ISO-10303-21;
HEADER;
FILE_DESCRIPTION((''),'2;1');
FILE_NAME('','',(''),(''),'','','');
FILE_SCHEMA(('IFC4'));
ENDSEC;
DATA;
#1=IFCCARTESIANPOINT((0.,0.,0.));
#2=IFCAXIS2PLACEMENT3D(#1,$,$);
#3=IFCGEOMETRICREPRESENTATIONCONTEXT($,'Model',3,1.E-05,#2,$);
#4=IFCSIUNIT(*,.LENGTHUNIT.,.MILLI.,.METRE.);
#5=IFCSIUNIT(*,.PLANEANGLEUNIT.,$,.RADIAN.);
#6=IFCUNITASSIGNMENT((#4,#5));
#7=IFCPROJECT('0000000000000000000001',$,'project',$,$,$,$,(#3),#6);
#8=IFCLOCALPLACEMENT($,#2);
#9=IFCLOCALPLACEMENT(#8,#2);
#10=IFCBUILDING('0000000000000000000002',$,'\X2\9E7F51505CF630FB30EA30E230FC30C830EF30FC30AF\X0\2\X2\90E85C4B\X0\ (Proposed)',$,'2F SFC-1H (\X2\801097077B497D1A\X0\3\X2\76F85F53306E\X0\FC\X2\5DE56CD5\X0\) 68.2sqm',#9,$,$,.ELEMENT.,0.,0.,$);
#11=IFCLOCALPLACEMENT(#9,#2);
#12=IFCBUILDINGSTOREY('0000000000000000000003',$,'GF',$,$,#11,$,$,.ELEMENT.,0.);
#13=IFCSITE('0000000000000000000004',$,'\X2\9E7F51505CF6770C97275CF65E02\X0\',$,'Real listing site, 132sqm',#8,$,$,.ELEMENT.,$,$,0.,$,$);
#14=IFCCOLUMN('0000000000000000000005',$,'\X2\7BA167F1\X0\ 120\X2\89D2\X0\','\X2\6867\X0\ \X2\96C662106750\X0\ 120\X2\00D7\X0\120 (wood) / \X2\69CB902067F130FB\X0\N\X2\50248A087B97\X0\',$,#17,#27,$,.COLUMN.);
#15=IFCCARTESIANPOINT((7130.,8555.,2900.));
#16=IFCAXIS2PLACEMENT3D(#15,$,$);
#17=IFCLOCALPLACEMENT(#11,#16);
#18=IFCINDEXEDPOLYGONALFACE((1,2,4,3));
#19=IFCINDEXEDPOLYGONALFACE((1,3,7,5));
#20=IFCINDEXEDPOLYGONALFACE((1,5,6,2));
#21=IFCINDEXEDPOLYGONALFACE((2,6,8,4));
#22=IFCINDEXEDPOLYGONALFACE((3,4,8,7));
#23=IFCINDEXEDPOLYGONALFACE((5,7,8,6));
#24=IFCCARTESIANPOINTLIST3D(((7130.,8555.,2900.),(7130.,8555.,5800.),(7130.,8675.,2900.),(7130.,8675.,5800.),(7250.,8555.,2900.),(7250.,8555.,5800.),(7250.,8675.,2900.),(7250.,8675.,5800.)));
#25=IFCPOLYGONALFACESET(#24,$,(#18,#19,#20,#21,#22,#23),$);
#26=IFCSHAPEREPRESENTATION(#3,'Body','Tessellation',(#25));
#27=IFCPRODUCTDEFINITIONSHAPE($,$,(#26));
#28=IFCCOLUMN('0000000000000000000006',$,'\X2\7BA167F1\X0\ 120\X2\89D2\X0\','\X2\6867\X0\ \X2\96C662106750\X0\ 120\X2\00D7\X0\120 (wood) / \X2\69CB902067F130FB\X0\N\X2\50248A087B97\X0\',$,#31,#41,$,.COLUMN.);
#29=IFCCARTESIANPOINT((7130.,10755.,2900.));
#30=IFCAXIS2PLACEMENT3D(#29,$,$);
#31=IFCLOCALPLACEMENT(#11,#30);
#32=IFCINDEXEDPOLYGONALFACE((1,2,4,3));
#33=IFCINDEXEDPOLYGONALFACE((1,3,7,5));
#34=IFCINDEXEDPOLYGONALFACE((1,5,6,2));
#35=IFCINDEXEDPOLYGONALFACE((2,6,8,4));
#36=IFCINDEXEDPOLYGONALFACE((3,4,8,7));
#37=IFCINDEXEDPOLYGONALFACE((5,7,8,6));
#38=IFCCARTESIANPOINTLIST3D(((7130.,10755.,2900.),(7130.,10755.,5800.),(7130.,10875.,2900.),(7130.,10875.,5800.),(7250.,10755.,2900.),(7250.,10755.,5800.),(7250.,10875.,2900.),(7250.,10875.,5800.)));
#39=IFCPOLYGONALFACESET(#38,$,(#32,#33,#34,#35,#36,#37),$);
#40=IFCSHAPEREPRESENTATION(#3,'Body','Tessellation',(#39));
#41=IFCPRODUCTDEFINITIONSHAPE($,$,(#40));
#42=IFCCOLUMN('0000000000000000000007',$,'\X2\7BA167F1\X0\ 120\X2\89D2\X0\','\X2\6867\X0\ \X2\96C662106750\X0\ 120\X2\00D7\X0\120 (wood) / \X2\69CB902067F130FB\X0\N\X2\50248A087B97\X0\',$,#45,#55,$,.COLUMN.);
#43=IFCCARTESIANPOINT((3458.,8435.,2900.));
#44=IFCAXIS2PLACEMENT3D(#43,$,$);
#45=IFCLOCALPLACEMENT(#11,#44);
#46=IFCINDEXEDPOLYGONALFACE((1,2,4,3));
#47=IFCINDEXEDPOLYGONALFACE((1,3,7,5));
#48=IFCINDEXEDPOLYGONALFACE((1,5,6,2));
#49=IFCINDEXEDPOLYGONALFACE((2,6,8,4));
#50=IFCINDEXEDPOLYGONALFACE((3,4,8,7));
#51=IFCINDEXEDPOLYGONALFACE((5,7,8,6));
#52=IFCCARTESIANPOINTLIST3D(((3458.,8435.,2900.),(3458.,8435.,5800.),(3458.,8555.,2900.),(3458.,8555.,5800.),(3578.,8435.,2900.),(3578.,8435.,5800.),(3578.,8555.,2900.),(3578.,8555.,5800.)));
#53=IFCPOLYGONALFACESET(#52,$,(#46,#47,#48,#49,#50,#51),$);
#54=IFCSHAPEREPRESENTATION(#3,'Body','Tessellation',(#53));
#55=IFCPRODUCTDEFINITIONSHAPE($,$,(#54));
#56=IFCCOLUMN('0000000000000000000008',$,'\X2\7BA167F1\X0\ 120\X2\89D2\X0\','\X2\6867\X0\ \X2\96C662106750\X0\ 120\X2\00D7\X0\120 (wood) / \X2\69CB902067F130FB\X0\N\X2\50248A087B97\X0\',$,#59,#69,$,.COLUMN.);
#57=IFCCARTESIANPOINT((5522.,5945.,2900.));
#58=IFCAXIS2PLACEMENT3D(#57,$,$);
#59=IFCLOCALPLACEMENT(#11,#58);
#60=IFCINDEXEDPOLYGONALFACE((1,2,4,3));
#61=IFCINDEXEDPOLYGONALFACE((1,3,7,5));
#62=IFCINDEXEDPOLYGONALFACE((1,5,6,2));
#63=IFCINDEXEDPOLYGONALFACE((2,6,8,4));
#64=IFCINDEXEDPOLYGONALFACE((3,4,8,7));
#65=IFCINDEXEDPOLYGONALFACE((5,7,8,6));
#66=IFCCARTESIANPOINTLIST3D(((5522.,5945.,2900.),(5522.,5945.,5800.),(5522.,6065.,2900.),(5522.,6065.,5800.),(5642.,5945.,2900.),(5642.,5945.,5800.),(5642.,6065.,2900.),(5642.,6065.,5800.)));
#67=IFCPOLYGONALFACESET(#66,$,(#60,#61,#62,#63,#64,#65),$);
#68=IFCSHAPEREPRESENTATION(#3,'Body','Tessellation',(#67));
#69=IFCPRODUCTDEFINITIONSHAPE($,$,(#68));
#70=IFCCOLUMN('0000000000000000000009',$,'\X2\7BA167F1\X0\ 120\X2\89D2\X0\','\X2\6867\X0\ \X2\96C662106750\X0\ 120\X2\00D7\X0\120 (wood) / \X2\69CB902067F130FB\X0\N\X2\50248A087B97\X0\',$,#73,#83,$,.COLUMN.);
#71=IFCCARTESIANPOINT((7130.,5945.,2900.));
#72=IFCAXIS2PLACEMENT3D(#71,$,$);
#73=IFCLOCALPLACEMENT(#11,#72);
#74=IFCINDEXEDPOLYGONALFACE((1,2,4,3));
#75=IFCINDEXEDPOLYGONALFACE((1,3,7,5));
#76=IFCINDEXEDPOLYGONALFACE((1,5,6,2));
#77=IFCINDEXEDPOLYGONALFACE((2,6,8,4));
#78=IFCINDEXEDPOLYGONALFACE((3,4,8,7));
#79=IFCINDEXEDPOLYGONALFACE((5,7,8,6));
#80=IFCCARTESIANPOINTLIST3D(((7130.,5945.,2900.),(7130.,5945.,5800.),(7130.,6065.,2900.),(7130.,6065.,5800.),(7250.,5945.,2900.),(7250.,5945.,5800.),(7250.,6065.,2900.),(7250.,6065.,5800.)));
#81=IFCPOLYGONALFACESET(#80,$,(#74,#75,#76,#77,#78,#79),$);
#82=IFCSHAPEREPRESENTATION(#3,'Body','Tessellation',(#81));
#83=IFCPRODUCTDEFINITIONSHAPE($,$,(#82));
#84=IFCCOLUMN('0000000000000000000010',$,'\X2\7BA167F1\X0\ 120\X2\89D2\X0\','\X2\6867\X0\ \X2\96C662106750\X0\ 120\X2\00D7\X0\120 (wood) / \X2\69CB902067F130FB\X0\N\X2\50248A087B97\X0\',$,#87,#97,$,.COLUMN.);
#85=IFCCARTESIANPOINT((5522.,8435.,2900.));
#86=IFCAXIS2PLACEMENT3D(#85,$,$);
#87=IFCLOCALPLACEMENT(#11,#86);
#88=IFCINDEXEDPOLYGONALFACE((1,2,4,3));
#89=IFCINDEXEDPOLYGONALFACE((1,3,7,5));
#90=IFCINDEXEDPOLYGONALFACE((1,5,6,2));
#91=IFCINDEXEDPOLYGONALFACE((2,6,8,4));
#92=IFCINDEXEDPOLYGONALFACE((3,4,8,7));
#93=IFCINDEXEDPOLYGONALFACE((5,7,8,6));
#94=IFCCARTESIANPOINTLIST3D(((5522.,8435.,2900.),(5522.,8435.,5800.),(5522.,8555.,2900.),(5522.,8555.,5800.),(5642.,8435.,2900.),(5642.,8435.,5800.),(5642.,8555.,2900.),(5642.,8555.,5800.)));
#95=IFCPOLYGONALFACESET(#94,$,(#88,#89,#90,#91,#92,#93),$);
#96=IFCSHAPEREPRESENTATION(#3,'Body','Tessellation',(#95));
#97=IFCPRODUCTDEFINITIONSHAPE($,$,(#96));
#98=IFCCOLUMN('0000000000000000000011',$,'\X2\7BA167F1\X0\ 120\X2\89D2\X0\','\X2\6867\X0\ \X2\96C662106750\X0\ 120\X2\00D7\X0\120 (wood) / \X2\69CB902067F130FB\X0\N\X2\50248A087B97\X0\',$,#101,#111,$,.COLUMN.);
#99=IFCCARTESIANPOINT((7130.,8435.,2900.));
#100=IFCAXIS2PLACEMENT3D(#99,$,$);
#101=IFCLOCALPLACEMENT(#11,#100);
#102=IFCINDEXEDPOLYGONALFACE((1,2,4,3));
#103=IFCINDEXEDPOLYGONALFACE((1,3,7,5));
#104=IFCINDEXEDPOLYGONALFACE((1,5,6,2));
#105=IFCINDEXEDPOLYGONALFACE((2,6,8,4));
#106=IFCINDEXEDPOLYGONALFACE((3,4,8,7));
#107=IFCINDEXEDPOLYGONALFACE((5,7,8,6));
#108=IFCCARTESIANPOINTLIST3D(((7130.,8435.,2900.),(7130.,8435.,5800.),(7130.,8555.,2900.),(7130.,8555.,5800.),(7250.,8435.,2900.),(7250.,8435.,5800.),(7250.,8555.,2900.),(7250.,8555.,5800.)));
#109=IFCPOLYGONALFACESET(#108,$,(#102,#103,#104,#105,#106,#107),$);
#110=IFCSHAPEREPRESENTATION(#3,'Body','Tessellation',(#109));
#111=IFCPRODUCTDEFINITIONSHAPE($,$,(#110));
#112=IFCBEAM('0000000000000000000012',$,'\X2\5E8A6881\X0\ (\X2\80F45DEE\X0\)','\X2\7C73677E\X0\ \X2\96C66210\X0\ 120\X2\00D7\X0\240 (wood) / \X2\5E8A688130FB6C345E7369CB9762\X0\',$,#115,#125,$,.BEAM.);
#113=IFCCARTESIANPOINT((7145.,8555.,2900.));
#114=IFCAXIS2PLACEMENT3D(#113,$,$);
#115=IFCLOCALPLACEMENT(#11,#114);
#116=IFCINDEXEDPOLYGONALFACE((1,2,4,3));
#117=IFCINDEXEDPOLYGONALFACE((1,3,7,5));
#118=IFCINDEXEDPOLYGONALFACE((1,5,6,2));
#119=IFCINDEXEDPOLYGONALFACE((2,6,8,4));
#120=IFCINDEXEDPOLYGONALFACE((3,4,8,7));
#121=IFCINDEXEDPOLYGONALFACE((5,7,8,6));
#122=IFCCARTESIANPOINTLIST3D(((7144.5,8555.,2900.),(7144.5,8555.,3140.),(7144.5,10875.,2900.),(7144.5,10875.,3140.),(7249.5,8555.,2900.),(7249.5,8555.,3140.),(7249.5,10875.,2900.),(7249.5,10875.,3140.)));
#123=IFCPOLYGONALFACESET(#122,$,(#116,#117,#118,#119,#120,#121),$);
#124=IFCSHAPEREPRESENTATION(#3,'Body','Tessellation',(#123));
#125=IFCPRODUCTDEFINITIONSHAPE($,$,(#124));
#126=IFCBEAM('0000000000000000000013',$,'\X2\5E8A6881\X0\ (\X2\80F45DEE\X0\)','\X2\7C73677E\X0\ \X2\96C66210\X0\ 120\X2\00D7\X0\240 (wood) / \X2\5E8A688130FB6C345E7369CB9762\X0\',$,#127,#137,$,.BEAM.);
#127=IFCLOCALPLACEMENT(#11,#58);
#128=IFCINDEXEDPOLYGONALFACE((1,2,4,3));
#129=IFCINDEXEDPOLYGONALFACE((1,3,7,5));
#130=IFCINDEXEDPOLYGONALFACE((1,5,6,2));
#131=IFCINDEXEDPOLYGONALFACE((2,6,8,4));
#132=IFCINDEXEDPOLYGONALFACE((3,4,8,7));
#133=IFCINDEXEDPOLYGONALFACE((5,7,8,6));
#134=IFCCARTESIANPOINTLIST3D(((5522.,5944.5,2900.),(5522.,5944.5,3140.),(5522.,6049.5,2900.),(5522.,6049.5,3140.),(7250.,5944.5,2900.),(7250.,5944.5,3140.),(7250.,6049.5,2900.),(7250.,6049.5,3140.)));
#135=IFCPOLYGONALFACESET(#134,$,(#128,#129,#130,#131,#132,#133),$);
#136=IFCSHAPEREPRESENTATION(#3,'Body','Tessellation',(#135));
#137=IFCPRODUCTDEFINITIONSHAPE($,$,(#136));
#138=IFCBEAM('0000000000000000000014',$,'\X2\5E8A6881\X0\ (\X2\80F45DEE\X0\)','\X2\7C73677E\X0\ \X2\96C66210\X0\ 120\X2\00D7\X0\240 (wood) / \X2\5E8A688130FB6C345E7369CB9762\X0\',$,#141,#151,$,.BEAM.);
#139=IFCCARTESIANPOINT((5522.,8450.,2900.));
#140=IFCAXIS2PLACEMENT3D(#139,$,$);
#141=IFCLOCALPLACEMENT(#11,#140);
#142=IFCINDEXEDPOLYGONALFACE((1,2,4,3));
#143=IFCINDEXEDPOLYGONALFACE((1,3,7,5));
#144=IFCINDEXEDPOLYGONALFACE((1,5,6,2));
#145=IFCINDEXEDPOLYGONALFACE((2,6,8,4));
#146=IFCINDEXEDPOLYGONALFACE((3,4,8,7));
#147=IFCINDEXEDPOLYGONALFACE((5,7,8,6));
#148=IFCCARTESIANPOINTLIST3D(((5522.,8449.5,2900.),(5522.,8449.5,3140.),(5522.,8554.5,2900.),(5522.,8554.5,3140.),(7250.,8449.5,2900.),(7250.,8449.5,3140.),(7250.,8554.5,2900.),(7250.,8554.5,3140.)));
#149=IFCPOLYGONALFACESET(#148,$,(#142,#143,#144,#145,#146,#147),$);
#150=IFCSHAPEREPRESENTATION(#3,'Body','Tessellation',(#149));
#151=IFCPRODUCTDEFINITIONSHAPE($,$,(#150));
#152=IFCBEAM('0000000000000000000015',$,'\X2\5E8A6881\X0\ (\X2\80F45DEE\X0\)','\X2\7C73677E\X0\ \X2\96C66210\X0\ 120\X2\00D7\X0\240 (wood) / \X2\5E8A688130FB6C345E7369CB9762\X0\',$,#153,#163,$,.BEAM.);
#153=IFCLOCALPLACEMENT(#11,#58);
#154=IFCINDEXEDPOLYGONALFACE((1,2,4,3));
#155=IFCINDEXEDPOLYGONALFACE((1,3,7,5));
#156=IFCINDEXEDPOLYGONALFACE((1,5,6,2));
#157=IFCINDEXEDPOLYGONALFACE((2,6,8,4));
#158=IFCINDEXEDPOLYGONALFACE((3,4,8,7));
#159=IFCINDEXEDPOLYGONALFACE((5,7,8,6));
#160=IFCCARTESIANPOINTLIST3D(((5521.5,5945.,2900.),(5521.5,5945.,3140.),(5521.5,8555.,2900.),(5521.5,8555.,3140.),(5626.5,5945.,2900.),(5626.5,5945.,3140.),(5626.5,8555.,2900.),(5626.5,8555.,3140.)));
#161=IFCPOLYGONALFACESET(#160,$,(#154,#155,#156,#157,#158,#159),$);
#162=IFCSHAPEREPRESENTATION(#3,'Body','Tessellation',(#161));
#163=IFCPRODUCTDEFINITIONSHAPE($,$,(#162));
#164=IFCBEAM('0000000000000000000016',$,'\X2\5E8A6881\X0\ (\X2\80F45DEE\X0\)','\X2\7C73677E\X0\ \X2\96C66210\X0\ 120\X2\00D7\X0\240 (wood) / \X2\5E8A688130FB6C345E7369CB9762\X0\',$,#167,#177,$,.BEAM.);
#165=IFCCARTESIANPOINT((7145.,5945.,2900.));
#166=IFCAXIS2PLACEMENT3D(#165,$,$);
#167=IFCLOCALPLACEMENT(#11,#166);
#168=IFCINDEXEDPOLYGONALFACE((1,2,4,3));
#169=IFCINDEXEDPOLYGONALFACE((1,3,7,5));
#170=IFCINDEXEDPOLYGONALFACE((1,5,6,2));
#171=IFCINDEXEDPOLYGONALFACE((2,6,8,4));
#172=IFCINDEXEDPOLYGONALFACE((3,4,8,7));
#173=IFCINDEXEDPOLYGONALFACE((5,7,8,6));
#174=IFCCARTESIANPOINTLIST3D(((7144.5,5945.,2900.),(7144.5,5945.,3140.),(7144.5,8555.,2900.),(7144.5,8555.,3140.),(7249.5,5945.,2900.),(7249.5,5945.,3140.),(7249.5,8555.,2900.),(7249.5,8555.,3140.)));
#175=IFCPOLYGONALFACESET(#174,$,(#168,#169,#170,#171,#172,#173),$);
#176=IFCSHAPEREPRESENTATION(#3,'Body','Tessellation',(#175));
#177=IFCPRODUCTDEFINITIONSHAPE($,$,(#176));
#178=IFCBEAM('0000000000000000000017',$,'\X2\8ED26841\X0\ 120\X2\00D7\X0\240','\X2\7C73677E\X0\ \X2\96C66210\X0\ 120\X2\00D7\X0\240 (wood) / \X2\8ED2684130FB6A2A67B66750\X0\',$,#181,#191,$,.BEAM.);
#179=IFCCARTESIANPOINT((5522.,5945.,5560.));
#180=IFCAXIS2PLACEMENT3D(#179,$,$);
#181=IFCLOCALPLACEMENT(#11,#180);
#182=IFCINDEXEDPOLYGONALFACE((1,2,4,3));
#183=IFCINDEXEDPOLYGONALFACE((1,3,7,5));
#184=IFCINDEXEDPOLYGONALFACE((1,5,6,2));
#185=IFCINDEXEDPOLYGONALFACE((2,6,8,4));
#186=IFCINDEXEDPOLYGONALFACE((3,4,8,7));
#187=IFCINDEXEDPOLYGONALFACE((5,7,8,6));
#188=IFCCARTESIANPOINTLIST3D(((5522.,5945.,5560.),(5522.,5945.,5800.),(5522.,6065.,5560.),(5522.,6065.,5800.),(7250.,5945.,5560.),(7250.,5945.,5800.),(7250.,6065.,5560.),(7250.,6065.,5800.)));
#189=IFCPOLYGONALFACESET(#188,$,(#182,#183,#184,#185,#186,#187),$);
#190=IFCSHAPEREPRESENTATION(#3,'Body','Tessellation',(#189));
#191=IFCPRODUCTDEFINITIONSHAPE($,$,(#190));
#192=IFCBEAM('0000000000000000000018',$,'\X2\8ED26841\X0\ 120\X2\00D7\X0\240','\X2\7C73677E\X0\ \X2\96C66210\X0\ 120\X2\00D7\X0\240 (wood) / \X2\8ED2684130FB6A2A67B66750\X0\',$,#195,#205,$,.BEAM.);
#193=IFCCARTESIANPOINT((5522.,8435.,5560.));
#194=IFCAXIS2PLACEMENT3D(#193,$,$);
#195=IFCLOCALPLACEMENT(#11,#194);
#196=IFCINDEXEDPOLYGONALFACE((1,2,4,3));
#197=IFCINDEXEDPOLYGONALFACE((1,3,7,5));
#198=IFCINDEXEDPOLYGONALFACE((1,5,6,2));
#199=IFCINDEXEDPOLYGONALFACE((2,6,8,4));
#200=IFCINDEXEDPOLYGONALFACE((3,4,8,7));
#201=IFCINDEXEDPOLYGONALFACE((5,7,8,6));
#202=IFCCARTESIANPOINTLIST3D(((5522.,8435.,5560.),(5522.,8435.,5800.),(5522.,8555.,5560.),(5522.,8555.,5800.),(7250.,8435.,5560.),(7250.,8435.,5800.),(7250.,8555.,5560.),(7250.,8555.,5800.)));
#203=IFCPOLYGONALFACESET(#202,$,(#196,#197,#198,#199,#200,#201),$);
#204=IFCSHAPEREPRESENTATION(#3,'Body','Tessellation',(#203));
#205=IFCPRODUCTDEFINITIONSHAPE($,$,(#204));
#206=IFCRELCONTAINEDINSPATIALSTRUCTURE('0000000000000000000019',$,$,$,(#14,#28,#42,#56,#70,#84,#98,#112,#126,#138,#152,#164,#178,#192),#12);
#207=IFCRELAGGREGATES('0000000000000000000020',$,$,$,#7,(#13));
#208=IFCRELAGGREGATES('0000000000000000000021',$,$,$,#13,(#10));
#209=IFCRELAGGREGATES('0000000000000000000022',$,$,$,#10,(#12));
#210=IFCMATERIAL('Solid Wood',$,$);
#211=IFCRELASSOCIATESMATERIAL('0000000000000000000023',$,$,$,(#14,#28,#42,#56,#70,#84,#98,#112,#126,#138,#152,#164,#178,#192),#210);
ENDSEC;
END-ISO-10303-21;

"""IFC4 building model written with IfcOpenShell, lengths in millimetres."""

from ifc_helpers import new_model, si_unit, frame, frame_2d, origin, place, context, project, spatial, rectangle, extrude, material, element, save


model = new_model("IFC4")

# Units and contexts
model_context = context("Model", 3, precision=1e-05, world=origin())
ifc_project = project(units=[si_unit("LENGTHUNIT", "METRE", prefix="MILLI"), si_unit("PLANEANGLEUNIT", "RADIAN")], contexts=[model_context])

# Site, building, storey
site_placement = place(None, origin())
site = spatial("IfcSite", under=ifc_project, at=site_placement, Name="鹿児島県霧島市", ObjectType="Real listing site, 132sqm", CompositionType="ELEMENT", RefElevation=0.0)
building_placement = place(site_placement, origin())
building = spatial("IfcBuilding", under=site, at=building_placement, Name="鹿児島・リモートワーク2部屋 (Proposed)", ObjectType="2F SFC-1H (耐震等級3相当のFC工法) 68.2sqm", CompositionType="ELEMENT", ElevationOfRefHeight=0.0, ElevationOfTerrain=0.0)
storey_placement = place(building_placement, origin())
storey = spatial("IfcBuildingStorey", under=building, at=storey_placement, Name="GF", CompositionType="ELEMENT", Elevation=0.0)

# Columns
ifc_material_1 = material(Name="Solid Wood")
column_1_placement = place(storey_placement, frame((7130.0, 8555.0, 2900.0)))
element("IfcColumn", 1, at=column_1_placement, inside=storey, material=ifc_material_1, Name="管柱 120角", Description="桧 集成材 120×120 (wood) / 構造柱・N値計算", PredefinedType="COLUMN", context=model_context, shape_type="SweptSolid", body=[
    extrude(rectangle(XDim=120.0, YDim=120.0, at=frame_2d((60.0, 60.0))), frame((7130.0, 8555.0, 2900.0)), (0.0, 0.0, 1.0), 2900.0),
])
column_2_placement = place(storey_placement, frame((7130.0, 10755.0, 2900.0)))
element("IfcColumn", 2, at=column_2_placement, inside=storey, material=ifc_material_1, Name="管柱 120角", Description="桧 集成材 120×120 (wood) / 構造柱・N値計算", PredefinedType="COLUMN", context=model_context, shape_type="SweptSolid", body=[
    extrude(rectangle(XDim=120.0, YDim=120.0, at=frame_2d((60.0, 60.0))), frame((7130.0, 10755.0, 2900.0)), (0.0, 0.0, 1.0), 2900.0),
])
column_3_placement = place(storey_placement, frame((3458.0, 8435.0, 2900.0)))
element("IfcColumn", 3, at=column_3_placement, inside=storey, material=ifc_material_1, Name="管柱 120角", Description="桧 集成材 120×120 (wood) / 構造柱・N値計算", PredefinedType="COLUMN", context=model_context, shape_type="SweptSolid", body=[
    extrude(rectangle(XDim=120.0, YDim=120.0, at=frame_2d((60.0, 60.0))), frame((3458.0, 8435.0, 2900.0)), (0.0, 0.0, 1.0), 2900.0),
])
column_4_placement = place(storey_placement, frame((5522.0, 5945.0, 2900.0)))
element("IfcColumn", 4, at=column_4_placement, inside=storey, material=ifc_material_1, Name="管柱 120角", Description="桧 集成材 120×120 (wood) / 構造柱・N値計算", PredefinedType="COLUMN", context=model_context, shape_type="SweptSolid", body=[
    extrude(rectangle(XDim=120.0, YDim=120.0, at=frame_2d((60.0, 60.0))), frame((5522.0, 5945.0, 2900.0)), (0.0, 0.0, 1.0), 2900.0),
])
column_5_placement = place(storey_placement, frame((7130.0, 5945.0, 2900.0)))
element("IfcColumn", 5, at=column_5_placement, inside=storey, material=ifc_material_1, Name="管柱 120角", Description="桧 集成材 120×120 (wood) / 構造柱・N値計算", PredefinedType="COLUMN", context=model_context, shape_type="SweptSolid", body=[
    extrude(rectangle(XDim=120.0, YDim=120.0, at=frame_2d((60.0, 60.0))), frame((7130.0, 5945.0, 2900.0)), (0.0, 0.0, 1.0), 2900.0),
])
column_6_placement = place(storey_placement, frame((5522.0, 8435.0, 2900.0)))
element("IfcColumn", 6, at=column_6_placement, inside=storey, material=ifc_material_1, Name="管柱 120角", Description="桧 集成材 120×120 (wood) / 構造柱・N値計算", PredefinedType="COLUMN", context=model_context, shape_type="SweptSolid", body=[
    extrude(rectangle(XDim=120.0, YDim=120.0, at=frame_2d((60.0, 60.0))), frame((5522.0, 8435.0, 2900.0)), (0.0, 0.0, 1.0), 2900.0),
])
column_7_placement = place(storey_placement, frame((7130.0, 8435.0, 2900.0)))
element("IfcColumn", 7, at=column_7_placement, inside=storey, material=ifc_material_1, Name="管柱 120角", Description="桧 集成材 120×120 (wood) / 構造柱・N値計算", PredefinedType="COLUMN", context=model_context, shape_type="SweptSolid", body=[
    extrude(rectangle(XDim=120.0, YDim=120.0, at=frame_2d((60.0, 60.0))), frame((7130.0, 8435.0, 2900.0)), (0.0, 0.0, 1.0), 2900.0),
])

# Beams
beam_1_placement = place(storey_placement, frame((7145.0, 8555.0, 2900.0)))
element("IfcBeam", 8, at=beam_1_placement, inside=storey, material=ifc_material_1, Name="床梁 (胴差)", Description="米松 集成 120×240 (wood) / 床梁・水平構面", PredefinedType="BEAM", context=model_context, shape_type="SweptSolid", body=[
    extrude(rectangle(XDim=105.0, YDim=2320.0, at=frame_2d((52.0, 1160.0))), frame((7145.0, 8555.0, 2900.0)), (0.0, 0.0, 1.0), 240.0),
])
beam_2_placement = place(storey_placement, frame((5522.0, 5945.0, 2900.0)))
element("IfcBeam", 9, at=beam_2_placement, inside=storey, material=ifc_material_1, Name="床梁 (胴差)", Description="米松 集成 120×240 (wood) / 床梁・水平構面", PredefinedType="BEAM", context=model_context, shape_type="SweptSolid", body=[
    extrude(rectangle(XDim=1728.0, YDim=105.0, at=frame_2d((864.0, 52.0))), frame((5522.0, 5945.0, 2900.0)), (0.0, 0.0, 1.0), 240.0),
])
beam_3_placement = place(storey_placement, frame((5522.0, 8450.0, 2900.0)))
element("IfcBeam", 10, at=beam_3_placement, inside=storey, material=ifc_material_1, Name="床梁 (胴差)", Description="米松 集成 120×240 (wood) / 床梁・水平構面", PredefinedType="BEAM", context=model_context, shape_type="SweptSolid", body=[
    extrude(rectangle(XDim=1728.0, YDim=105.0, at=frame_2d((864.0, 52.0))), frame((5522.0, 8450.0, 2900.0)), (0.0, 0.0, 1.0), 240.0),
])
beam_4_placement = place(storey_placement, frame((5522.0, 5945.0, 2900.0)))
element("IfcBeam", 11, at=beam_4_placement, inside=storey, material=ifc_material_1, Name="床梁 (胴差)", Description="米松 集成 120×240 (wood) / 床梁・水平構面", PredefinedType="BEAM", context=model_context, shape_type="SweptSolid", body=[
    extrude(rectangle(XDim=105.0, YDim=2610.0, at=frame_2d((52.0, 1305.0))), frame((5522.0, 5945.0, 2900.0)), (0.0, 0.0, 1.0), 240.0),
])
beam_5_placement = place(storey_placement, frame((7145.0, 5945.0, 2900.0)))
element("IfcBeam", 12, at=beam_5_placement, inside=storey, material=ifc_material_1, Name="床梁 (胴差)", Description="米松 集成 120×240 (wood) / 床梁・水平構面", PredefinedType="BEAM", context=model_context, shape_type="SweptSolid", body=[
    extrude(rectangle(XDim=105.0, YDim=2610.0, at=frame_2d((52.0, 1305.0))), frame((7145.0, 5945.0, 2900.0)), (0.0, 0.0, 1.0), 240.0),
])
beam_6_placement = place(storey_placement, frame((5522.0, 5945.0, 5560.0)))
element("IfcBeam", 13, at=beam_6_placement, inside=storey, material=ifc_material_1, Name="軒桁 120×240", Description="米松 集成 120×240 (wood) / 軒桁・横架材", PredefinedType="BEAM", context=model_context, shape_type="SweptSolid", body=[
    extrude(rectangle(XDim=1728.0, YDim=120.0, at=frame_2d((864.0, 60.0))), frame((5522.0, 5945.0, 5560.0)), (0.0, 0.0, 1.0), 240.0),
])
beam_7_placement = place(storey_placement, frame((5522.0, 8435.0, 5560.0)))
element("IfcBeam", 14, at=beam_7_placement, inside=storey, material=ifc_material_1, Name="軒桁 120×240", Description="米松 集成 120×240 (wood) / 軒桁・横架材", PredefinedType="BEAM", context=model_context, shape_type="SweptSolid", body=[
    extrude(rectangle(XDim=1728.0, YDim=120.0, at=frame_2d((864.0, 60.0))), frame((5522.0, 8435.0, 5560.0)), (0.0, 0.0, 1.0), 240.0),
])

save(model, "model.ifc")
